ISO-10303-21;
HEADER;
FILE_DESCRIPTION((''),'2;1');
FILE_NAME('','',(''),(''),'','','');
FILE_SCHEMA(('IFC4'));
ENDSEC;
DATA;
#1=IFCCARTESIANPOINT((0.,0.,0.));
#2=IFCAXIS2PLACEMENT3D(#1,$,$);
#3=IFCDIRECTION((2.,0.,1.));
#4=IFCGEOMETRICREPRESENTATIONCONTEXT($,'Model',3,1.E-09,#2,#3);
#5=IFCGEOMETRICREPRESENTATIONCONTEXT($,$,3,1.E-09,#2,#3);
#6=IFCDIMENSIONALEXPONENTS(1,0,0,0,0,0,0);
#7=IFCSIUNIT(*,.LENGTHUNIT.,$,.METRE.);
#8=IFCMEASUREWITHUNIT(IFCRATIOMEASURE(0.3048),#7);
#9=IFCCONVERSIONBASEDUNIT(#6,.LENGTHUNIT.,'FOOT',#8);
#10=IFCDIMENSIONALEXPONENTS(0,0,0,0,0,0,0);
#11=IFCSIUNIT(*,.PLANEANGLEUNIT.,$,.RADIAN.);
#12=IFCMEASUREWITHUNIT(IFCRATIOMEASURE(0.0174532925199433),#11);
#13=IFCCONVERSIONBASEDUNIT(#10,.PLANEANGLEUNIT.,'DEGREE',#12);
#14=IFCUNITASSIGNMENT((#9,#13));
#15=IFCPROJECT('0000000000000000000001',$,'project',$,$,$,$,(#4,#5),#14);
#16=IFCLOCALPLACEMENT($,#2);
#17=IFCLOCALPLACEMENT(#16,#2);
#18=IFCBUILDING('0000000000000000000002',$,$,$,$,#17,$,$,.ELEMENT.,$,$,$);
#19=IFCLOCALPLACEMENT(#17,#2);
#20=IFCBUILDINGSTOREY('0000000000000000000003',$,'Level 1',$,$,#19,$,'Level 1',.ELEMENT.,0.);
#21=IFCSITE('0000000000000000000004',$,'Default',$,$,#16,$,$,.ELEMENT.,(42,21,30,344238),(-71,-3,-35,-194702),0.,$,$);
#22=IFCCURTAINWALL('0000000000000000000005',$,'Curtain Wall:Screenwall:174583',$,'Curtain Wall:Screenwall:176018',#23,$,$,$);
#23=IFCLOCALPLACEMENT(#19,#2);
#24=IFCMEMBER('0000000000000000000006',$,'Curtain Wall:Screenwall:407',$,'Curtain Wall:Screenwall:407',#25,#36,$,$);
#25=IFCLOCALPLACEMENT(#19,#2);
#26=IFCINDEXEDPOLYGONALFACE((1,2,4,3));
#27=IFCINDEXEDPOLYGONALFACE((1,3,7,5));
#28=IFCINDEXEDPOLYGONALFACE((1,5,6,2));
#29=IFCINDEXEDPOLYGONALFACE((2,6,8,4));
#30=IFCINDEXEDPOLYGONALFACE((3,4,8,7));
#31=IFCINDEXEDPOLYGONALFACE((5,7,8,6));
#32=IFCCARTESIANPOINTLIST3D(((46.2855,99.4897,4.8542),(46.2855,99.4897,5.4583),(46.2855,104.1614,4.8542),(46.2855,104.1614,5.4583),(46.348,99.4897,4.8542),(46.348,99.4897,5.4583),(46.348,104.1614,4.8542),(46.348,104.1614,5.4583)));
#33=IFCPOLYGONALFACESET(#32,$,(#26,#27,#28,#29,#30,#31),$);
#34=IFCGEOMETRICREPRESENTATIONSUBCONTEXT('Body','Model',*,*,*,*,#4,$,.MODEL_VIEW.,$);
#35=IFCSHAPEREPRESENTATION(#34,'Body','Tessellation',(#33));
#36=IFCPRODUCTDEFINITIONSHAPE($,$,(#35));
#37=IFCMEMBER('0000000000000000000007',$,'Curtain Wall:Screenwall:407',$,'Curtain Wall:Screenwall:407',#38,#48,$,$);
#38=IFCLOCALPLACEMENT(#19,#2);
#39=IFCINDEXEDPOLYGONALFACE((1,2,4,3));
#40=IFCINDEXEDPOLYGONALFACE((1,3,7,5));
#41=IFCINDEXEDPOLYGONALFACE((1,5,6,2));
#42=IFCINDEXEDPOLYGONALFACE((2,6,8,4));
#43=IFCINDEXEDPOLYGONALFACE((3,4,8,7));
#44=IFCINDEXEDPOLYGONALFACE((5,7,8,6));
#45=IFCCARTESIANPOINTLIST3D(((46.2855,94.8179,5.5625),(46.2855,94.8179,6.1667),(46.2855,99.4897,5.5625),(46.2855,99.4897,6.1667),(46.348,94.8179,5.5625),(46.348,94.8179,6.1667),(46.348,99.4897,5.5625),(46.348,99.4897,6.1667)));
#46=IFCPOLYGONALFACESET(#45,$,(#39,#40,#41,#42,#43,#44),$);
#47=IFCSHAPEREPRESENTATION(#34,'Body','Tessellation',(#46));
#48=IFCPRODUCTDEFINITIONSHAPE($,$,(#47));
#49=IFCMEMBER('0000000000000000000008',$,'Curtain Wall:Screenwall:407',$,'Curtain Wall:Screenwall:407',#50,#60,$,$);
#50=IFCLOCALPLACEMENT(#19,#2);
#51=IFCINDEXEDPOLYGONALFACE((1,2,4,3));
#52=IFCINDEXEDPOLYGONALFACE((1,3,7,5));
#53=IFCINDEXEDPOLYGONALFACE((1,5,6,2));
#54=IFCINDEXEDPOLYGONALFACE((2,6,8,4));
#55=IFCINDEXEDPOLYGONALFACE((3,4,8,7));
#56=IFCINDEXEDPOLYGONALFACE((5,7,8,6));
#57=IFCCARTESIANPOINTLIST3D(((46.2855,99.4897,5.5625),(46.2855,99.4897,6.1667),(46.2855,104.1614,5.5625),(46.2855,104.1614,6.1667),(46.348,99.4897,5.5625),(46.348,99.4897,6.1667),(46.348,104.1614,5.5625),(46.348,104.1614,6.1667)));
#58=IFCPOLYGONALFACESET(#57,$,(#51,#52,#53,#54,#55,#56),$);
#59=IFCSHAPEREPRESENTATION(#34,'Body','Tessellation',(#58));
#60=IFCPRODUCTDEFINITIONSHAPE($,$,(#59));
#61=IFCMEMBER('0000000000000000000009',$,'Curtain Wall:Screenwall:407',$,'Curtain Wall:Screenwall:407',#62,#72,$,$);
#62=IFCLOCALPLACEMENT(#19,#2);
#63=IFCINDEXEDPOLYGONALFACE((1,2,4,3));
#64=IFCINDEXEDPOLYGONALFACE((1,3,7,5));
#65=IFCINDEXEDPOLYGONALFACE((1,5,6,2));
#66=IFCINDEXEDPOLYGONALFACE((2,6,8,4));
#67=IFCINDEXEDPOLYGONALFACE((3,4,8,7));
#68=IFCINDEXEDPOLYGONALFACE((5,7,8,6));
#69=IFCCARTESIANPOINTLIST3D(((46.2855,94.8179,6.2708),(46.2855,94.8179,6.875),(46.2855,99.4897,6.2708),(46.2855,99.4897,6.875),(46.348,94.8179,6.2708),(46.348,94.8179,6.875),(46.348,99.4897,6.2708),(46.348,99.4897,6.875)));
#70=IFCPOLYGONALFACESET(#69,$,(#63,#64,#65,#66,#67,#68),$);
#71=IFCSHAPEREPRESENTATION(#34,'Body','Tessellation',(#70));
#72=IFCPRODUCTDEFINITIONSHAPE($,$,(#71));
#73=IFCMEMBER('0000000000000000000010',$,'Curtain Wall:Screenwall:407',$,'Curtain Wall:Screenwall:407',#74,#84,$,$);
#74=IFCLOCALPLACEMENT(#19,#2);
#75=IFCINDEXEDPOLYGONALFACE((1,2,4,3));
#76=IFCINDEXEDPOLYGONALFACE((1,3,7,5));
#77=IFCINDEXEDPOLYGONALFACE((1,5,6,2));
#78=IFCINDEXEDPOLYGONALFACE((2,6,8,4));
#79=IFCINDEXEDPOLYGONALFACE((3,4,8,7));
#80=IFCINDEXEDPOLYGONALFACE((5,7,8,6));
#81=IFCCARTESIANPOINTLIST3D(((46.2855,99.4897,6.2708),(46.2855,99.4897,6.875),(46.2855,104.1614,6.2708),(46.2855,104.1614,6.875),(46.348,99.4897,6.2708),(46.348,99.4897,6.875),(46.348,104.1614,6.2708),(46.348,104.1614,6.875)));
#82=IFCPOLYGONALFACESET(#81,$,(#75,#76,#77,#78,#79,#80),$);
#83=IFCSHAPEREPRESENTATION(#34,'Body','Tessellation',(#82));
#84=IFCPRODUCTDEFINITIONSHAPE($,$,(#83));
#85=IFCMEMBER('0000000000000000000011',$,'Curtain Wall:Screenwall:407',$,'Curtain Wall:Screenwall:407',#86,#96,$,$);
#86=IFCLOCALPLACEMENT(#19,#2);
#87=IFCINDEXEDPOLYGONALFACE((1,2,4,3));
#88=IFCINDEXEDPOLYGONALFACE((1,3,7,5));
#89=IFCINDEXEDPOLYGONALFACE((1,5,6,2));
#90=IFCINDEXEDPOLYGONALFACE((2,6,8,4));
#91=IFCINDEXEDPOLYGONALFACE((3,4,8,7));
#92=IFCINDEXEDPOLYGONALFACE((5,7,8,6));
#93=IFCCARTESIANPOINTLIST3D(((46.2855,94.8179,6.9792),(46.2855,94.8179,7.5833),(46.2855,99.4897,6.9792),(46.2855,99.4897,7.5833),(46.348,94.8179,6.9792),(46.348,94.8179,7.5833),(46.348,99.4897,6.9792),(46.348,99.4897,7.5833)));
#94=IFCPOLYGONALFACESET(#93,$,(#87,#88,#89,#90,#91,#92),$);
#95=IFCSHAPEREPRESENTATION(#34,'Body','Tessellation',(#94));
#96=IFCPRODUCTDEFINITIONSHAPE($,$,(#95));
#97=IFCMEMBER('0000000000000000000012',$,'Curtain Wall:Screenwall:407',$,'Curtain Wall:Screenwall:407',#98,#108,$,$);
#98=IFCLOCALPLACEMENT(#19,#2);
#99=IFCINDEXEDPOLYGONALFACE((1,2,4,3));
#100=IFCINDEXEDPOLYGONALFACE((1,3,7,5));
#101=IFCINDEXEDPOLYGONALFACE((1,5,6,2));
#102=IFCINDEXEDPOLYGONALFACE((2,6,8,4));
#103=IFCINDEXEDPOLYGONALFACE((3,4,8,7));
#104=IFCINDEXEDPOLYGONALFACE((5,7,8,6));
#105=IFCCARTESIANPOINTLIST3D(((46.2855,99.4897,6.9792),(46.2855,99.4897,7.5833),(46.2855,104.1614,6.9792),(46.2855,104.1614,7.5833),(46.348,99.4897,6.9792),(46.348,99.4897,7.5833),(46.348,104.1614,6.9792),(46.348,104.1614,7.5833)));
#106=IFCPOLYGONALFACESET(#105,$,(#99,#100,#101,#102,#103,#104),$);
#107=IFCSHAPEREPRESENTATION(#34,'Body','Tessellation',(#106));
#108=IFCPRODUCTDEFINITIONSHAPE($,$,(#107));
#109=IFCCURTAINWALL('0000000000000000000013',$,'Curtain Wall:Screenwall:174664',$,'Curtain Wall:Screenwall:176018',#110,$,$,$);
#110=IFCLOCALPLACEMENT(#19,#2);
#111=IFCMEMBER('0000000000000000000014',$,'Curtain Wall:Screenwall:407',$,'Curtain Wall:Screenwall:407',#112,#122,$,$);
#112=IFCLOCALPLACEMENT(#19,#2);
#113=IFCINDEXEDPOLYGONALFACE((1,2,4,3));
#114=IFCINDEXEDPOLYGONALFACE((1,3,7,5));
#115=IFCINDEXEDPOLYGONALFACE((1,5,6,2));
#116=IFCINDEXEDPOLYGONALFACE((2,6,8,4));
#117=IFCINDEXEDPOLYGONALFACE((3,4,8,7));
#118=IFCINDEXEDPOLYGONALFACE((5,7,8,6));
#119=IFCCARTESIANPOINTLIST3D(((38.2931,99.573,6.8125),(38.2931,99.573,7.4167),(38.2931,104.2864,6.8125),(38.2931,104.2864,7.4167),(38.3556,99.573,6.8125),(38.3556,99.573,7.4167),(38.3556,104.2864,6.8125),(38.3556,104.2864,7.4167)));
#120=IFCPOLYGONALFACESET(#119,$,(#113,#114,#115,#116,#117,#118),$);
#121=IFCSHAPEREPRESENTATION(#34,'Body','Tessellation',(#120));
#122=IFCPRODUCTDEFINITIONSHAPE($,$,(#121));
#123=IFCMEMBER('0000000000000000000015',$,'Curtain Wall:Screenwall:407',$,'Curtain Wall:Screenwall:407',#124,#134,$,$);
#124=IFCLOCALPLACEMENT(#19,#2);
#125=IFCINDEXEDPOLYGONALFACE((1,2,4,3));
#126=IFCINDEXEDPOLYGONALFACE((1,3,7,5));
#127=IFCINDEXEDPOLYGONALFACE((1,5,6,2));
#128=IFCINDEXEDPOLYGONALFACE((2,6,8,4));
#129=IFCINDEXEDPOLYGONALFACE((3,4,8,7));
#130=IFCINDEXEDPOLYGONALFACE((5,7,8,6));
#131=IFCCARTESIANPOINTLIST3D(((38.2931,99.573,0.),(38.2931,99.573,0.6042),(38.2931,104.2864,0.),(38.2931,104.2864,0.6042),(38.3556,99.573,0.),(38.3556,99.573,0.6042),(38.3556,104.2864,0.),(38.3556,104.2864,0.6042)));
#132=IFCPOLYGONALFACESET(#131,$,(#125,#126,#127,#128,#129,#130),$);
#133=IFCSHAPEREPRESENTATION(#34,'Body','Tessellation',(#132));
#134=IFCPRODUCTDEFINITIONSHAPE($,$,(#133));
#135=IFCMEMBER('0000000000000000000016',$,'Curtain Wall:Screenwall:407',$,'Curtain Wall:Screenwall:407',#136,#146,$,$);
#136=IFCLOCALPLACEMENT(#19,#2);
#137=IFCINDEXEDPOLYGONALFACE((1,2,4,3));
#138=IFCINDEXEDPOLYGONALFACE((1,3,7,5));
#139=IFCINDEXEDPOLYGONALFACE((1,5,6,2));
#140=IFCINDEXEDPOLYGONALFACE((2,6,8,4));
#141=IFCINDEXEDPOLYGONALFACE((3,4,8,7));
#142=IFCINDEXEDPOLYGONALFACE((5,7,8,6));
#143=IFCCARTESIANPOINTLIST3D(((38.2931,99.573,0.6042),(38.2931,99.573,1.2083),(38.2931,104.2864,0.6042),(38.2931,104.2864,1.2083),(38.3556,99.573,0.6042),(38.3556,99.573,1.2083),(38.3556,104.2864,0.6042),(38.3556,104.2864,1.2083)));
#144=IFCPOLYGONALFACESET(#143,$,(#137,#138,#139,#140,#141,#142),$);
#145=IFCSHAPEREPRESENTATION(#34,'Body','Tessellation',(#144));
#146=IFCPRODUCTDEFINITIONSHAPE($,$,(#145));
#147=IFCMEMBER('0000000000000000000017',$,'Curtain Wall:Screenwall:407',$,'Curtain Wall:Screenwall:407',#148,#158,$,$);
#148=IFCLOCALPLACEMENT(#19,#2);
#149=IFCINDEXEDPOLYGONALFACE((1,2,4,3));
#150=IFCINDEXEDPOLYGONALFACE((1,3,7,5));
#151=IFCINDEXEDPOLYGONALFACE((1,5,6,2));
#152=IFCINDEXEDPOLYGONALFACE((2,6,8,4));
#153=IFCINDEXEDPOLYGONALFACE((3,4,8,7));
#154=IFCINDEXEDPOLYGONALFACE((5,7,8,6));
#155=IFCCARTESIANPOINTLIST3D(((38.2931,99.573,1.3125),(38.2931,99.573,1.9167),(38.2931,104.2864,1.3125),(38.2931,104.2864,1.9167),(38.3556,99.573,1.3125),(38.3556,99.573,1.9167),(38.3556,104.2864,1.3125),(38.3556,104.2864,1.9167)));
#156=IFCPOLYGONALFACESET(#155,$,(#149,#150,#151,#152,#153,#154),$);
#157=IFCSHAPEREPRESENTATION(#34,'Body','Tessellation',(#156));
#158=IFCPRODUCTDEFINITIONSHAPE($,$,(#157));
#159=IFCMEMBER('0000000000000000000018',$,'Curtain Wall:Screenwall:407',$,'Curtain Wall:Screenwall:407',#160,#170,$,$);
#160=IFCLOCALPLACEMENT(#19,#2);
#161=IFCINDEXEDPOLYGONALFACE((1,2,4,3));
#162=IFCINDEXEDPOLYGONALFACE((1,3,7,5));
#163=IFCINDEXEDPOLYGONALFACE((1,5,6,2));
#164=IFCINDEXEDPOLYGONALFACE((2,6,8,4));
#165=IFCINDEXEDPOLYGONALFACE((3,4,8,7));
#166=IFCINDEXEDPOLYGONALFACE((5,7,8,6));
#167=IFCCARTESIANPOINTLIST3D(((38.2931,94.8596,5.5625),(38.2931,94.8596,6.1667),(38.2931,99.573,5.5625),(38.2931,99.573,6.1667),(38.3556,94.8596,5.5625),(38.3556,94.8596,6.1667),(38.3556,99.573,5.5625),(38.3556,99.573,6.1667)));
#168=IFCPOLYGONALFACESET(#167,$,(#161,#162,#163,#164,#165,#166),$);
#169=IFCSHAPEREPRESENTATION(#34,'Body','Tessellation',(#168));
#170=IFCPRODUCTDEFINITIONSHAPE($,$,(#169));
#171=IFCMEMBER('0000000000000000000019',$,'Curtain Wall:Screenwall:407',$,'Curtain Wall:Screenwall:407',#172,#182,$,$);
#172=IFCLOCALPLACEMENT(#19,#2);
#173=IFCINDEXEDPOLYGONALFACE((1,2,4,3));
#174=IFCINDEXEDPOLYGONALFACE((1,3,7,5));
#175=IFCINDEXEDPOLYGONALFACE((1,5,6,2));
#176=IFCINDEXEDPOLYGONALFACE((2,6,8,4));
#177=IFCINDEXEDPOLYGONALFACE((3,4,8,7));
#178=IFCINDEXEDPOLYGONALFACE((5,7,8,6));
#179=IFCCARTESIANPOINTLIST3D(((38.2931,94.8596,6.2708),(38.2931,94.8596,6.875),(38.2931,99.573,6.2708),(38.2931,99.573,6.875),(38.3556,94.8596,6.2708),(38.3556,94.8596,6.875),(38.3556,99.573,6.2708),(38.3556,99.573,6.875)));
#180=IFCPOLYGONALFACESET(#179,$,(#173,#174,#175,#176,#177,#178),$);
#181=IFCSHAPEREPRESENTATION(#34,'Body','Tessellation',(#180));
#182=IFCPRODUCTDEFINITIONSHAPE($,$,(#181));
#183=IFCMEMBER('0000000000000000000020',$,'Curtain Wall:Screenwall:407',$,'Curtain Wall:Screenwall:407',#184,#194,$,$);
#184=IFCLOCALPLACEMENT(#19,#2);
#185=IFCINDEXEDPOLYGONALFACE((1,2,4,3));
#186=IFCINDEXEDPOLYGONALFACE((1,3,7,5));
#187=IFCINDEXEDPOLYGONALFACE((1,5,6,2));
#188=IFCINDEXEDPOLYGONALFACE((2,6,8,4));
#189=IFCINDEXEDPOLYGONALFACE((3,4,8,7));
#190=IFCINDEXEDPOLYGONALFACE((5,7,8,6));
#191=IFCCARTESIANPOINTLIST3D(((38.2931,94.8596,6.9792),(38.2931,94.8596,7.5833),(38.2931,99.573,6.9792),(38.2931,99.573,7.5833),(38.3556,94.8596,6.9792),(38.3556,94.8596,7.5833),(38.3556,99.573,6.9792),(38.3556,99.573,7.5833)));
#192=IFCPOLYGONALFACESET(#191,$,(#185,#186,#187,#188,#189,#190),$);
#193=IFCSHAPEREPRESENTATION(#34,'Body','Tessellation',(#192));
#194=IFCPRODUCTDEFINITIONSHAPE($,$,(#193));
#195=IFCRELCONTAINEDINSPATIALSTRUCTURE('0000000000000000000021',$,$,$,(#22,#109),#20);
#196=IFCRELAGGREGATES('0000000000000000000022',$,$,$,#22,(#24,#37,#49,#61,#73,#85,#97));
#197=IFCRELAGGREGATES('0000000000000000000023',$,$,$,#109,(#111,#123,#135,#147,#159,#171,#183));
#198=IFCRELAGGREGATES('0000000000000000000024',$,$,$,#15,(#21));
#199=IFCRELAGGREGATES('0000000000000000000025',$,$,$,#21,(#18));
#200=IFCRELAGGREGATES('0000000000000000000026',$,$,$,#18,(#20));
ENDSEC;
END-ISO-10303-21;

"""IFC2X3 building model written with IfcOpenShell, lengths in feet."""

from ifc_helpers import new_model, entity, si_unit, converted_unit, direction, frame, frame_2d, origin, origin_2d_with_axis, place, context, subcontext, project, spatial, rectangle, extrude, element, aggregate, save


model = new_model("IFC2X3")

# Units and contexts
model_context = context("Model", 3, precision=1e-09, world=origin(), true_north=direction((2.0, 0.0, 1.0)))
context_of_model = context(None, 3, precision=1e-09, world=origin(), true_north=direction((2.0, 0.0, 1.0)))
body_context = subcontext(model_context, "Body", "Model", "MODEL_VIEW")
ifc_project = project(units=[converted_unit("LENGTHUNIT", "FOOT", entity("IfcRatioMeasure", 0.3048), si_unit("LENGTHUNIT", "METRE"), dimensions=[1, 0, 0, 0, 0, 0, 0]), converted_unit("PLANEANGLEUNIT", "DEGREE", entity("IfcRatioMeasure", 0.0174532925199433), si_unit("PLANEANGLEUNIT", "RADIAN"), dimensions=[0, 0, 0, 0, 0, 0, 0])], contexts=[model_context, context_of_model])

# Site, building, storey
site_placement = place(None, origin())
site = spatial("IfcSite", under=ifc_project, at=site_placement, Name="Default", CompositionType="ELEMENT", RefLatitude=(42, 21, 30, 344238), RefLongitude=(-71, -3, -35, -194702), RefElevation=0.0)
building_placement = place(site_placement, origin())
building = spatial("IfcBuilding", under=site, at=building_placement, CompositionType="ELEMENT")
storey_placement = place(building_placement, origin())
storey = spatial("IfcBuildingStorey", under=building, at=storey_placement, Name="Level 1", LongName="Level 1", CompositionType="ELEMENT", Elevation=0.0)

# Curtain walls, members
curtain_wall_1_placement = place(storey_placement, origin())
curtain_wall_1 = element("IfcCurtainWall", 1, at=curtain_wall_1_placement, inside=storey, Name="Curtain Wall:Screenwall:174583", ObjectType="Curtain Wall:Screenwall:176018")
member_1_placement = place(curtain_wall_1_placement, frame((46.2855, 99.4897, 4.8542)))
member_1 = element("IfcMember", 2, at=member_1_placement, Name="Curtain Wall:Screenwall:407", ObjectType="Curtain Wall:Screenwall:407", context=body_context, shape_type="SweptSolid", body=[
    extrude(rectangle(XDim=4.6717, YDim=0.0625, at=frame_2d((0.0, 0.0), x_axis=(1.0, 0.0))), frame((0.0313, 2.3359, 0.0), z_axis=(0.0, 0.0, 1.0), x_axis=(0.0, -1.0, 0.0)), (0.0, 0.0, 1.0), 0.6042),
])
member_2_placement = place(curtain_wall_1_placement, frame((46.2855, 94.8179, 5.5625)))
member_2 = element("IfcMember", 3, at=member_2_placement, Name="Curtain Wall:Screenwall:407", ObjectType="Curtain Wall:Screenwall:407", context=body_context, shape_type="SweptSolid", body=[
    extrude(rectangle(XDim=4.6717, YDim=0.0625, at=frame_2d((0.0, 0.0), x_axis=(1.0, 0.0))), frame((0.0312, 2.3359, 0.0), z_axis=(0.0, 0.0, 1.0), x_axis=(0.0, -1.0, 0.0)), (0.0, 0.0, 1.0), 0.6042),
])
member_3_placement = place(curtain_wall_1_placement, frame((46.2855, 99.4897, 5.5625)))
member_3 = element("IfcMember", 4, at=member_3_placement, Name="Curtain Wall:Screenwall:407", ObjectType="Curtain Wall:Screenwall:407", context=body_context, shape_type="SweptSolid", body=[
    extrude(rectangle(XDim=4.6717, YDim=0.0625, at=frame_2d((0.0, 0.0), x_axis=(1.0, 0.0))), frame((0.0313, 2.3359, 0.0), z_axis=(0.0, 0.0, 1.0), x_axis=(0.0, -1.0, 0.0)), (0.0, 0.0, 1.0), 0.6042),
])
member_4_placement = place(curtain_wall_1_placement, frame((46.2855, 94.8179, 6.2708)))
member_4 = element("IfcMember", 5, at=member_4_placement, Name="Curtain Wall:Screenwall:407", ObjectType="Curtain Wall:Screenwall:407", context=body_context, shape_type="SweptSolid", body=[
    extrude(rectangle(XDim=4.6717, YDim=0.0625, at=frame_2d((0.0, 0.0), x_axis=(1.0, 0.0))), frame((0.0312, 2.3359, 0.0), z_axis=(0.0, 0.0, 1.0), x_axis=(0.0, -1.0, 0.0)), (0.0, 0.0, 1.0), 0.6042),
])
member_5_placement = place(curtain_wall_1_placement, frame((46.2855, 99.4897, 6.2708)))
member_5 = element("IfcMember", 6, at=member_5_placement, Name="Curtain Wall:Screenwall:407", ObjectType="Curtain Wall:Screenwall:407", context=body_context, shape_type="SweptSolid", body=[
    extrude(rectangle(XDim=4.6717, YDim=0.0625, at=frame_2d((0.0, 0.0), x_axis=(1.0, 0.0))), frame((0.0313, 2.3359, 0.0), z_axis=(0.0, 0.0, 1.0), x_axis=(0.0, -1.0, 0.0)), (0.0, 0.0, 1.0), 0.6042),
])
member_6_placement = place(curtain_wall_1_placement, frame((46.2855, 94.8179, 6.9792)))
member_6 = element("IfcMember", 7, at=member_6_placement, Name="Curtain Wall:Screenwall:407", ObjectType="Curtain Wall:Screenwall:407", context=body_context, shape_type="SweptSolid", body=[
    extrude(rectangle(XDim=4.6717, YDim=0.0625, at=frame_2d((0.0, 0.0), x_axis=(1.0, 0.0))), frame((0.0312, 2.3359, 0.0), z_axis=(0.0, 0.0, 1.0), x_axis=(0.0, -1.0, 0.0)), (0.0, 0.0, 1.0), 0.6042),
])
member_7_placement = place(curtain_wall_1_placement, frame((46.2855, 99.4897, 6.9792)))
member_7 = element("IfcMember", 8, at=member_7_placement, Name="Curtain Wall:Screenwall:407", ObjectType="Curtain Wall:Screenwall:407", context=body_context, shape_type="SweptSolid", body=[
    extrude(rectangle(XDim=4.6717, YDim=0.0625, at=frame_2d((0.0, 0.0), x_axis=(1.0, 0.0))), frame((0.0313, 2.3359, 0.0), z_axis=(0.0, 0.0, 1.0), x_axis=(0.0, -1.0, 0.0)), (0.0, 0.0, 1.0), 0.6042),
])
aggregate(curtain_wall_1, [member_1, member_2, member_3, member_4, member_5, member_6, member_7])
curtain_wall_2_placement = place(storey_placement, origin())
curtain_wall_2 = element("IfcCurtainWall", 9, at=curtain_wall_2_placement, inside=storey, Name="Curtain Wall:Screenwall:174664", ObjectType="Curtain Wall:Screenwall:176018")
member_8_placement = place(curtain_wall_2_placement, frame((38.2931, 99.573, 6.8125)))
member_8 = element("IfcMember", 10, at=member_8_placement, Name="Curtain Wall:Screenwall:407", ObjectType="Curtain Wall:Screenwall:407", context=body_context, shape_type="SweptSolid", body=[
    extrude(rectangle(XDim=4.7134, YDim=0.0625, at=frame_2d((0.0, 0.0), x_axis=(1.0, 0.0))), frame((0.0312, 2.3567, 0.0), z_axis=(0.0, 0.0, 1.0), x_axis=(0.0, 1.0, 0.0)), (0.0, 0.0, 1.0), 0.6042),
])
member_9_placement = place(curtain_wall_2_placement, frame((38.2931, 99.573, 0.0)))
member_9 = element("IfcMember", 11, at=member_9_placement, Name="Curtain Wall:Screenwall:407", ObjectType="Curtain Wall:Screenwall:407", context=body_context, shape_type="SweptSolid", body=[
    extrude(rectangle(XDim=4.7134, YDim=0.0625, at=origin_2d_with_axis()), frame((0.0312, 2.3567, 0.0), z_axis=(0.0, 0.0, 1.0), x_axis=(0.0, -1.0, 0.0)), (0.0, 0.0, 1.0), 0.6042),
])
member_10_placement = place(curtain_wall_2_placement, frame((38.2931, 99.573, 0.6042)))
member_10 = element("IfcMember", 12, at=member_10_placement, Name="Curtain Wall:Screenwall:407", ObjectType="Curtain Wall:Screenwall:407", context=body_context, shape_type="SweptSolid", body=[
    extrude(rectangle(XDim=4.7134, YDim=0.0625, at=frame_2d((0.0, 0.0), x_axis=(1.0, 0.0))), frame((0.0312, 2.3567, 0.0), z_axis=(0.0, 0.0, 1.0), x_axis=(0.0, 1.0, 0.0)), (0.0, 0.0, 1.0), 0.6042),
])
member_11_placement = place(curtain_wall_2_placement, frame((38.2931, 99.573, 1.3125)))
member_11 = element("IfcMember", 13, at=member_11_placement, Name="Curtain Wall:Screenwall:407", ObjectType="Curtain Wall:Screenwall:407", context=body_context, shape_type="SweptSolid", body=[
    extrude(rectangle(XDim=4.7134, YDim=0.0625, at=frame_2d((0.0, 0.0), x_axis=(1.0, 0.0))), frame((0.0312, 2.3567, 0.0), z_axis=(0.0, 0.0, 1.0), x_axis=(0.0, 1.0, 0.0)), (0.0, 0.0, 1.0), 0.6042),
])
member_12_placement = place(curtain_wall_2_placement, frame((38.2931, 94.8596, 5.5625)))
member_12 = element("IfcMember", 14, at=member_12_placement, Name="Curtain Wall:Screenwall:407", ObjectType="Curtain Wall:Screenwall:407", context=body_context, shape_type="SweptSolid", body=[
    extrude(rectangle(XDim=4.7134, YDim=0.0625, at=origin_2d_with_axis()), frame((0.0312, 2.3567, 0.0), z_axis=(0.0, 0.0, 1.0), x_axis=(0.0, 1.0, 0.0)), (0.0, 0.0, 1.0), 0.6042),
])
member_13_placement = place(curtain_wall_2_placement, frame((38.2931, 94.8596, 6.2708)))
member_13 = element("IfcMember", 15, at=member_13_placement, Name="Curtain Wall:Screenwall:407", ObjectType="Curtain Wall:Screenwall:407", context=body_context, shape_type="SweptSolid", body=[
    extrude(rectangle(XDim=4.7134, YDim=0.0625, at=origin_2d_with_axis()), frame((0.0312, 2.3567, 0.0), z_axis=(0.0, 0.0, 1.0), x_axis=(0.0, 1.0, 0.0)), (0.0, 0.0, 1.0), 0.6042),
])
member_14_placement = place(curtain_wall_2_placement, frame((38.2931, 94.8596, 6.9792)))
member_14 = element("IfcMember", 16, at=member_14_placement, Name="Curtain Wall:Screenwall:407", ObjectType="Curtain Wall:Screenwall:407", context=body_context, shape_type="SweptSolid", body=[
    extrude(rectangle(XDim=4.7134, YDim=0.0625, at=origin_2d_with_axis()), frame((0.0312, 2.3567, 0.0), z_axis=(0.0, 0.0, 1.0), x_axis=(0.0, 1.0, 0.0)), (0.0, 0.0, 1.0), 0.6042),
])
aggregate(curtain_wall_2, [member_8, member_9, member_10, member_11, member_12, member_13, member_14])

save(model, "model.ifc")
